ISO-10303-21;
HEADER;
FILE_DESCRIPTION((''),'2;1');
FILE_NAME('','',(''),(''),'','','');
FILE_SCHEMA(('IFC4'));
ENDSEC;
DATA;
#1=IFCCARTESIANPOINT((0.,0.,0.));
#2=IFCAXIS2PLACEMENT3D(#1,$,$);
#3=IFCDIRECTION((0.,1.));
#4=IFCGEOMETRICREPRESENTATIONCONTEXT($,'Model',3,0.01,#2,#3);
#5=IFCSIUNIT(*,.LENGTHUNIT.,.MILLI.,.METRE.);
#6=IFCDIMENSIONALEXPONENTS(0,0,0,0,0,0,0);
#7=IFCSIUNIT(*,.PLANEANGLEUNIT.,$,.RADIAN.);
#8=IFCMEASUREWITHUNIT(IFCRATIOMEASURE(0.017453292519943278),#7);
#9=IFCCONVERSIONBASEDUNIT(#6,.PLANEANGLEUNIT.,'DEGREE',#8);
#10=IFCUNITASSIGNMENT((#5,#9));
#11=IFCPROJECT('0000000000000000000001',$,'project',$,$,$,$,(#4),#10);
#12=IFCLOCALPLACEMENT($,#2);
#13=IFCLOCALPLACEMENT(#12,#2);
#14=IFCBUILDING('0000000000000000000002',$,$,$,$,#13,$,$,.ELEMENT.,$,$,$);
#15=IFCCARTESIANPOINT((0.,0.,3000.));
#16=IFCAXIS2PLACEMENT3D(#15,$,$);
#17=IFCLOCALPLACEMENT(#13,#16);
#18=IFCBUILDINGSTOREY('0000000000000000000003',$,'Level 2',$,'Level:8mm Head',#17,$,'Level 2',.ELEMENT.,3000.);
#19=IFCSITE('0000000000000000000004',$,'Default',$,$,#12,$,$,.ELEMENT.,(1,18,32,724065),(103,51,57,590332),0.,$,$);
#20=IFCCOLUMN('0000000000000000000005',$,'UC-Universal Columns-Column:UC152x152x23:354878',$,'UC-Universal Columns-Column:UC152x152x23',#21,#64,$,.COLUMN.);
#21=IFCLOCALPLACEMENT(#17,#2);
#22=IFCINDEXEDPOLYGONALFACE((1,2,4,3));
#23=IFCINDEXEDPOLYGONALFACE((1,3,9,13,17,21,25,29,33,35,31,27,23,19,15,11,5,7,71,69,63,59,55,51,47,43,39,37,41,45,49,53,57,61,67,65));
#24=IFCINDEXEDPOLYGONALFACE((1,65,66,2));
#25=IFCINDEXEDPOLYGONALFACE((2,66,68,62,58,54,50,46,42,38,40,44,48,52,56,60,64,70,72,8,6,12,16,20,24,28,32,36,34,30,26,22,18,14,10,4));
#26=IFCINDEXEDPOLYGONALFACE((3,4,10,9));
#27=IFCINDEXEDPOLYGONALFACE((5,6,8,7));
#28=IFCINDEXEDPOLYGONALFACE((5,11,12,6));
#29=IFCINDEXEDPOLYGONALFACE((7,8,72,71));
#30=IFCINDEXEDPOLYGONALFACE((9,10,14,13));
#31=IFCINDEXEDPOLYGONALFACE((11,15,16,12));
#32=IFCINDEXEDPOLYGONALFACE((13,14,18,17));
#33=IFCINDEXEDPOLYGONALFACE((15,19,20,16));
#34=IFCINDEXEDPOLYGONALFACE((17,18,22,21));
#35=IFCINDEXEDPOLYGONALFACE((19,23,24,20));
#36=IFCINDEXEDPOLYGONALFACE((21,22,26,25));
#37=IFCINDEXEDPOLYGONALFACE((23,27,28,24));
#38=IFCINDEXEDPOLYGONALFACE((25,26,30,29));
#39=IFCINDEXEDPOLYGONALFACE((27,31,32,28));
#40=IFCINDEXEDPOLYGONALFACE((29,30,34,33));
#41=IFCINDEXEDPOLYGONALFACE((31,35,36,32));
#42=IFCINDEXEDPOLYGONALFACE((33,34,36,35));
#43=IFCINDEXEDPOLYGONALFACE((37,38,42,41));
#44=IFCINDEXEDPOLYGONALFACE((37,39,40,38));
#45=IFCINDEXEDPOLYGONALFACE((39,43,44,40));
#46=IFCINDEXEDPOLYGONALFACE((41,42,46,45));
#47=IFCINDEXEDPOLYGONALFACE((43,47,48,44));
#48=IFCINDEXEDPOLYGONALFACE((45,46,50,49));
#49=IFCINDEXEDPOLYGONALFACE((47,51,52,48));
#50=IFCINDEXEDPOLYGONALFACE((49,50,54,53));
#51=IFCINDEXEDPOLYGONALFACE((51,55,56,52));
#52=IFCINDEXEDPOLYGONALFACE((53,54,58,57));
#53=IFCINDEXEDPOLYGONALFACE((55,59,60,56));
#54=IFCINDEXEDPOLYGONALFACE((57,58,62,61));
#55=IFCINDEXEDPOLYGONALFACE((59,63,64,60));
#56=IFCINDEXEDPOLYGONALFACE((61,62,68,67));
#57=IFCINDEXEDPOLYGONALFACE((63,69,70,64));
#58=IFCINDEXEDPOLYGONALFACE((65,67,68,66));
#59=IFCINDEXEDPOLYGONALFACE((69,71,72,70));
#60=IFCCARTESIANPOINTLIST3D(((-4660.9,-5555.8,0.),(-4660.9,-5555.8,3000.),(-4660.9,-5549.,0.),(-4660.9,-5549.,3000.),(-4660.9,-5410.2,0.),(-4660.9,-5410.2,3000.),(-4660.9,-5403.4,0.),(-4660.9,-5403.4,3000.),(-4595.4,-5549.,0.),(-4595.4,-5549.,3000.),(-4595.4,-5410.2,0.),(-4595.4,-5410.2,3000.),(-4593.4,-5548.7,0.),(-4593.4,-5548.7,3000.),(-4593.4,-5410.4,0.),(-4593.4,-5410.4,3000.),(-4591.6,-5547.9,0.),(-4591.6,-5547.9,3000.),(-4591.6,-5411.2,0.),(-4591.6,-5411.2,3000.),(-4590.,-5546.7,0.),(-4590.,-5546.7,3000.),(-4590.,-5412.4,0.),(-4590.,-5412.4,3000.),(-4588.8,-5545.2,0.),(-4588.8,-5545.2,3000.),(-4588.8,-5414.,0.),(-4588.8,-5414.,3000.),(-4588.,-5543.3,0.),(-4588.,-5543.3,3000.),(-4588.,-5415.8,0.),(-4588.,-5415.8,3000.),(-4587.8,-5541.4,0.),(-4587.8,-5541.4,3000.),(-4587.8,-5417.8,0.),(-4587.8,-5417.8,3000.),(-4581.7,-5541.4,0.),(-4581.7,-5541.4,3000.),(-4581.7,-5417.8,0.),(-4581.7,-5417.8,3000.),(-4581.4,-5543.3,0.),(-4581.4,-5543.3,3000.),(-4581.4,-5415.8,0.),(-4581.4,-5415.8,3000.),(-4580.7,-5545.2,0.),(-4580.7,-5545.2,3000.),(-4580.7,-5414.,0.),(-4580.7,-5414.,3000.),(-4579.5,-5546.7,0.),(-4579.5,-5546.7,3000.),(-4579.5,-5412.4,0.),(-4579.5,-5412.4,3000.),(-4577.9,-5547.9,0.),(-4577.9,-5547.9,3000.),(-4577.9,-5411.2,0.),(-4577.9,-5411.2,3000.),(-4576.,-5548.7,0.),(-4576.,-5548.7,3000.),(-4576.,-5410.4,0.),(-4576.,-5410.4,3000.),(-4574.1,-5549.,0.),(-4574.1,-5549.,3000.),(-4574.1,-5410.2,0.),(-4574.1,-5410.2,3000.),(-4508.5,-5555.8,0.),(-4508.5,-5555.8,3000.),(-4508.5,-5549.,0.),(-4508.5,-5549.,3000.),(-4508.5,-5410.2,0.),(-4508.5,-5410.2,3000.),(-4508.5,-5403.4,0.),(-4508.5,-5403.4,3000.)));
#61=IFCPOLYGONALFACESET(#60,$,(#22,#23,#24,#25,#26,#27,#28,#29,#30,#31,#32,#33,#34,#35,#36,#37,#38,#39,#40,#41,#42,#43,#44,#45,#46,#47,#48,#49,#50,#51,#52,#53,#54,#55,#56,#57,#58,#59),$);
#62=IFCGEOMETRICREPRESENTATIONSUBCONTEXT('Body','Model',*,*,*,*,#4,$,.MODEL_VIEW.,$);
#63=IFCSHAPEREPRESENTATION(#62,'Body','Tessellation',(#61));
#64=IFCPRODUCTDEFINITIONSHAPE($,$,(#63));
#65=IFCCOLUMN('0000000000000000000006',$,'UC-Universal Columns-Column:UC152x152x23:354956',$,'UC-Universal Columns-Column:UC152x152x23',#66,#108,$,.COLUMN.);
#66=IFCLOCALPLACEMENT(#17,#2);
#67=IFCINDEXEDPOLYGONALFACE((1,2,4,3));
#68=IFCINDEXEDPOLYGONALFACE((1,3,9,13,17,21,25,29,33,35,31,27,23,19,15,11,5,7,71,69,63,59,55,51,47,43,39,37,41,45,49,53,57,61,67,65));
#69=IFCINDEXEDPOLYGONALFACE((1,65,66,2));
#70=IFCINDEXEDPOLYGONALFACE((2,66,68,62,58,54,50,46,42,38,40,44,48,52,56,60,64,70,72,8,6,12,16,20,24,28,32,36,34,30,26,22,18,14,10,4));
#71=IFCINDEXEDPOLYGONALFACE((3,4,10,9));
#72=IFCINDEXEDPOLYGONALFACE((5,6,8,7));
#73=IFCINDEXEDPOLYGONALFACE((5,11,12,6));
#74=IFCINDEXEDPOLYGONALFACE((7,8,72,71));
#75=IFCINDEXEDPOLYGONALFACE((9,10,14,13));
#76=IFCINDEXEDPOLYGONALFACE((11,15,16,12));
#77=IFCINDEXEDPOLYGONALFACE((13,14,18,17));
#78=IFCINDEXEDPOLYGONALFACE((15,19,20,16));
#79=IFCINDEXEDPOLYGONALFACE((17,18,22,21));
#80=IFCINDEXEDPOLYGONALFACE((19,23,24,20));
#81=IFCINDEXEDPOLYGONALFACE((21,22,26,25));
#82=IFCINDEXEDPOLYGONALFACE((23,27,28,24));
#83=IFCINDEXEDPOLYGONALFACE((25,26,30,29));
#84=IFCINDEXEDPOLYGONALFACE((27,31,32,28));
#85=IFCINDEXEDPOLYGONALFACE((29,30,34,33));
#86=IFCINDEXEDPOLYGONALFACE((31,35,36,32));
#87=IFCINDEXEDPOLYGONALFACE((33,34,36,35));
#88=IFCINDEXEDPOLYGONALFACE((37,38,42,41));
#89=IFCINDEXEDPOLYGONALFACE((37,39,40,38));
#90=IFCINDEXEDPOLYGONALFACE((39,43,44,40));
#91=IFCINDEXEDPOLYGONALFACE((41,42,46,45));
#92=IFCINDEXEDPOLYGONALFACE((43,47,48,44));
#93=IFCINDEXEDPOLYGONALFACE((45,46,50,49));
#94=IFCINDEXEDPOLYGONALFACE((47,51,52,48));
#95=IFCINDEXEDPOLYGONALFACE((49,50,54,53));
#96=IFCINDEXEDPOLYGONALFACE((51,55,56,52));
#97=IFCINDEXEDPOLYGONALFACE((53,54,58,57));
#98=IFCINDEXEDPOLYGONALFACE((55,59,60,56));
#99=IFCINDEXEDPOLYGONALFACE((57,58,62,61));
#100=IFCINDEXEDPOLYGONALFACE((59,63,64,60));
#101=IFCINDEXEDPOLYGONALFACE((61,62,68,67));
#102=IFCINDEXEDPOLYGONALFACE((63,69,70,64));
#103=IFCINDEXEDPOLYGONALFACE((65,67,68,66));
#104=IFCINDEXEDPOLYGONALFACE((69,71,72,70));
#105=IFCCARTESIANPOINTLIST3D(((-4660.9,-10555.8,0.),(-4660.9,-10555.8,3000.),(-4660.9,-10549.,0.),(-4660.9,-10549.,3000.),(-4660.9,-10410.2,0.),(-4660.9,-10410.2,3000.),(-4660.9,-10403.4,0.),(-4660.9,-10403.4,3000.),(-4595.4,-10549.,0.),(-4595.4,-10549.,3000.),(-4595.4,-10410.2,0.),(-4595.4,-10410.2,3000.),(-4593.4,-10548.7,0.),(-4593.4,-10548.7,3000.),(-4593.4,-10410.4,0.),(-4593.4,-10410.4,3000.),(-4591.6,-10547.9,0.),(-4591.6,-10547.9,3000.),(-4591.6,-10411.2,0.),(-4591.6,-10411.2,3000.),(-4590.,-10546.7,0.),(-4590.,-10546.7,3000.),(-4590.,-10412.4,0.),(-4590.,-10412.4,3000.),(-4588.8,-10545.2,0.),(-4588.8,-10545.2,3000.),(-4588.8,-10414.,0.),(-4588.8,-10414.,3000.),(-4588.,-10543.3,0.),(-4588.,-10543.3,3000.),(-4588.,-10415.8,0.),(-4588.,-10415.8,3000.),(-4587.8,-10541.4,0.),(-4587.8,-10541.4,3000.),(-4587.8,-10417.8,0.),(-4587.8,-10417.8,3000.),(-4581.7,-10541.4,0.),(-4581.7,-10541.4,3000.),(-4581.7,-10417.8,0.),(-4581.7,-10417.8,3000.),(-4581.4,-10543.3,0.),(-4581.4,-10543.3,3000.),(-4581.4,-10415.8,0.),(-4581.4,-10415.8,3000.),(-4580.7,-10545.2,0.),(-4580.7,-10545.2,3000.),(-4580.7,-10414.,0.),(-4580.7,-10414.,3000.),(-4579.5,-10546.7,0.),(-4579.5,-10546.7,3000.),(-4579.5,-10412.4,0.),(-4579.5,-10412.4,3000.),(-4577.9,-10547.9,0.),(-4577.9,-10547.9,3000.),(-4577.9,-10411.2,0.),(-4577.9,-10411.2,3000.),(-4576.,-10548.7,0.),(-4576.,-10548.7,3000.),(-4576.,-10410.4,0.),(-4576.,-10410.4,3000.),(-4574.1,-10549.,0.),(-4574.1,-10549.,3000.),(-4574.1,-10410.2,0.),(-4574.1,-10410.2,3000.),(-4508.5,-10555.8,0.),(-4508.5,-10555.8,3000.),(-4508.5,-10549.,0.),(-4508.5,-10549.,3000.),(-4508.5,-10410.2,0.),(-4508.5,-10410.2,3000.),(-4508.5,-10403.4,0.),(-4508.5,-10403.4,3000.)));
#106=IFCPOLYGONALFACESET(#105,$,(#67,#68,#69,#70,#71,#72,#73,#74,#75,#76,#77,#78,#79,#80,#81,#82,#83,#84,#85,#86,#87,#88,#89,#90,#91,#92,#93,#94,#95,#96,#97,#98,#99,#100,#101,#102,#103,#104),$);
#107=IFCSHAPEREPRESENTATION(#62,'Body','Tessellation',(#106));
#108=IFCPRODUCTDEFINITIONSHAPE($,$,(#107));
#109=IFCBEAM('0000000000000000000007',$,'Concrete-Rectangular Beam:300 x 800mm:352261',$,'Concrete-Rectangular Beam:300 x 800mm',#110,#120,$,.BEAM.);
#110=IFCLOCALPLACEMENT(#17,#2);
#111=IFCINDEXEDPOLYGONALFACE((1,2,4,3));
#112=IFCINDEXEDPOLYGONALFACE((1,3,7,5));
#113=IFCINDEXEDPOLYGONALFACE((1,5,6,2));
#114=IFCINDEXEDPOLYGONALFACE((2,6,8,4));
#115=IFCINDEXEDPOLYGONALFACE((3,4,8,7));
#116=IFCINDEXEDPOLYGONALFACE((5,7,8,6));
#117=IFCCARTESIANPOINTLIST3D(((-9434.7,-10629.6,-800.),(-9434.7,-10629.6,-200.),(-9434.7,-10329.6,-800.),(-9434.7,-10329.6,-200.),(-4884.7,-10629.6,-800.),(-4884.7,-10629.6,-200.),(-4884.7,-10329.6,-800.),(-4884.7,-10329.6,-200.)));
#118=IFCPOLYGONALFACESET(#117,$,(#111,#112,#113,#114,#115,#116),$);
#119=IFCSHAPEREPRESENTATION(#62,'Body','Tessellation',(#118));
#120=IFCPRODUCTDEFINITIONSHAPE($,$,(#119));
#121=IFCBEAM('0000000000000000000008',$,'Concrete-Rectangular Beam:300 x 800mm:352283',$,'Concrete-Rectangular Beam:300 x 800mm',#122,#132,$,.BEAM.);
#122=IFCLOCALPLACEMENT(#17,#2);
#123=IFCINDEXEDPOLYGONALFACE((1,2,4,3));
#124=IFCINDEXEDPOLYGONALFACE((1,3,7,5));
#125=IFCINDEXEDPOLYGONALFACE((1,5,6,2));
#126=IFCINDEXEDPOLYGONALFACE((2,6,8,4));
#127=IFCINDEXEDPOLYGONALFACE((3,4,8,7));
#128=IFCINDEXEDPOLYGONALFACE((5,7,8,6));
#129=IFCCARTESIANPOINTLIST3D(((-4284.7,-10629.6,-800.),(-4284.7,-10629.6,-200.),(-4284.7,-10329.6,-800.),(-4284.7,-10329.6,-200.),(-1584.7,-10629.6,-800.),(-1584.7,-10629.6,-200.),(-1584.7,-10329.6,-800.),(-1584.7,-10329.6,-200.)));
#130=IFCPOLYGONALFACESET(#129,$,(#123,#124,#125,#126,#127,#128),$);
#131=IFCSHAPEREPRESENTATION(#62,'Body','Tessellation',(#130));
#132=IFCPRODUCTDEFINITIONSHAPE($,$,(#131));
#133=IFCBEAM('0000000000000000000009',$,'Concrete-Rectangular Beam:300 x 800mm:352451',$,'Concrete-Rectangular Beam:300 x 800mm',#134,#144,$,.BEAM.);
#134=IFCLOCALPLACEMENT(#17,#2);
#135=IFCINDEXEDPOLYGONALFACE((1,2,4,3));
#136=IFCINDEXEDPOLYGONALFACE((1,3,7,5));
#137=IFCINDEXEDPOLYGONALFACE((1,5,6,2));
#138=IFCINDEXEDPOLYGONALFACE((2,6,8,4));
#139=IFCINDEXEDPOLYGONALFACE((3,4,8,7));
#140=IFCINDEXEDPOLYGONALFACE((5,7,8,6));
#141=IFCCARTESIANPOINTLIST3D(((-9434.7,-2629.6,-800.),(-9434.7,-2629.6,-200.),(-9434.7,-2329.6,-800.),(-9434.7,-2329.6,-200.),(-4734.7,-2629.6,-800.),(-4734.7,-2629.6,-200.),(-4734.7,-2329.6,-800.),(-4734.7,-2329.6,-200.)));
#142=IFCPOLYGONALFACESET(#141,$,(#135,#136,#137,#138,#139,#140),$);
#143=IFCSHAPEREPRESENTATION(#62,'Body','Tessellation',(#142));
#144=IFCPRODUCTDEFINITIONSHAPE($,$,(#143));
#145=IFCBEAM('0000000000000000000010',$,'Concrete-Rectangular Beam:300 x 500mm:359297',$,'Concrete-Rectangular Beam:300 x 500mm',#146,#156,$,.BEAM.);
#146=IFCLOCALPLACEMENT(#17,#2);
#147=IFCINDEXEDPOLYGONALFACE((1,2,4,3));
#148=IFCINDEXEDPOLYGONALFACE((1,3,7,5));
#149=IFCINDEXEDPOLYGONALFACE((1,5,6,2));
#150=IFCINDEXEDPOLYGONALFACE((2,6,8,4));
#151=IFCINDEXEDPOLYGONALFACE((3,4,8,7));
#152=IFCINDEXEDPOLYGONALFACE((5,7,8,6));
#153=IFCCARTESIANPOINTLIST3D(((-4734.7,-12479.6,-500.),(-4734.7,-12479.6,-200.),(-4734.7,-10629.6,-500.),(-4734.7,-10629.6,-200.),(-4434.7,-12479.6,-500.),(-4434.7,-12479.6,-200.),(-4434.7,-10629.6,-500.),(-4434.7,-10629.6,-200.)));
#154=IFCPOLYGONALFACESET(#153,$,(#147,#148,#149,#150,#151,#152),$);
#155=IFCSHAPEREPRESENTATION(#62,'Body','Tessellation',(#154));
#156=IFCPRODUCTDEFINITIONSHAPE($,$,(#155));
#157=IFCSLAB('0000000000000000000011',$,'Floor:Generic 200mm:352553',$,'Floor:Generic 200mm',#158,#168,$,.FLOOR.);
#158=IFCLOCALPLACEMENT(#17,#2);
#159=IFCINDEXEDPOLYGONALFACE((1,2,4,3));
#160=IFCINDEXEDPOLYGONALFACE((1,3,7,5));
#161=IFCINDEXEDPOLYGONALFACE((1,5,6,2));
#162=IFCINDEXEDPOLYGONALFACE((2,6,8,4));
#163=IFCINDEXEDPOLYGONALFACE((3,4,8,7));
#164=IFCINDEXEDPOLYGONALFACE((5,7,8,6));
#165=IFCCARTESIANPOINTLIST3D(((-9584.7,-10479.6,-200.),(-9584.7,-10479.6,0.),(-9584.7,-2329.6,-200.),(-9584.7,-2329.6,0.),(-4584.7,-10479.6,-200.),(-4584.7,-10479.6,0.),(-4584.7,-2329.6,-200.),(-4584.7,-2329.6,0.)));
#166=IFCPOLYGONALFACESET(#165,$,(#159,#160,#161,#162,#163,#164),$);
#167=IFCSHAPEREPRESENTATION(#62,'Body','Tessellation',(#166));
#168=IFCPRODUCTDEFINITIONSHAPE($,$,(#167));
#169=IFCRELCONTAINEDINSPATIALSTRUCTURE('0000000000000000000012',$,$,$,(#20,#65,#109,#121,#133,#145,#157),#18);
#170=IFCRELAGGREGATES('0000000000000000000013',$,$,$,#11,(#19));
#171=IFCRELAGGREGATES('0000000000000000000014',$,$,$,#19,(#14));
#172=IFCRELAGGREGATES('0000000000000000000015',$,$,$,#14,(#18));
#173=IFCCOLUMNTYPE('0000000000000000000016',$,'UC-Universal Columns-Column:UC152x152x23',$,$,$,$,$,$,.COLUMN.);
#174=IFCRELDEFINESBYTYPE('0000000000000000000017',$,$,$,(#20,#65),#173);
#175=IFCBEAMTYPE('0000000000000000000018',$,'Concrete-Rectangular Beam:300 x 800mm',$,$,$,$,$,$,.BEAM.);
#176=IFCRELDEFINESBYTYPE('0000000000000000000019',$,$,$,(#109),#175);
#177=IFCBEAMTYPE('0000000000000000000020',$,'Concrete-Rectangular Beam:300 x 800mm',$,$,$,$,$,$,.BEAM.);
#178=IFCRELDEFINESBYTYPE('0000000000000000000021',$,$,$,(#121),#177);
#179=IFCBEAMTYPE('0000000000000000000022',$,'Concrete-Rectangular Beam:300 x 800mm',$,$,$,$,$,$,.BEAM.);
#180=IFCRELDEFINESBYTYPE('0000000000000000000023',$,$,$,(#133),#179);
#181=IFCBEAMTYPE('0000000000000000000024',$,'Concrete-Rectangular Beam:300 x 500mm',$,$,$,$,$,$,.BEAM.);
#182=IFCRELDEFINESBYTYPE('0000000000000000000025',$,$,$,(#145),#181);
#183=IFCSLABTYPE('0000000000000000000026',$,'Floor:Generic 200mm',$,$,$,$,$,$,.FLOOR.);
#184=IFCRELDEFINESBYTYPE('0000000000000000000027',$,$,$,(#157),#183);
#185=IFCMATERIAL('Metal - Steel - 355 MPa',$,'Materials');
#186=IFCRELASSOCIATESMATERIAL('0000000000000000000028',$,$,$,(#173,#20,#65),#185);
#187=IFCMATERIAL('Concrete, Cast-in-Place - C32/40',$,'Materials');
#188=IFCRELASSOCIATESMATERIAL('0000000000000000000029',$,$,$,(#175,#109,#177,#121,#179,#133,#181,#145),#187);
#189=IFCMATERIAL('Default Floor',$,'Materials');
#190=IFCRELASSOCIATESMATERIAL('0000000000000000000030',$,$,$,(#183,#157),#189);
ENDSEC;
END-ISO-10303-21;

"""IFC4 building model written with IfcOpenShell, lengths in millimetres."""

from ifc_helpers import new_model, entity, si_unit, converted_unit, direction, frame, origin, place, context, subcontext, project, spatial, line, arc, indexed_curve, outline, extrude, source, transform, mapped, material, type_object, type_shapes, element, save


model = new_model("IFC4")

# Units and contexts
model_context = context("Model", 3, precision=0.01, world=origin(), true_north=direction((0.0, 1.0)))
body_context = subcontext(model_context, "Body", "Model", "MODEL_VIEW")
ifc_project = project(units=[si_unit("LENGTHUNIT", "METRE", prefix="MILLI"), converted_unit("PLANEANGLEUNIT", "DEGREE", entity("IfcRatioMeasure", 0.017453292519943278), si_unit("PLANEANGLEUNIT", "RADIAN"), dimensions=[0, 0, 0, 0, 0, 0, 0])], contexts=[model_context])

# Site, building, storey
site_placement = place(None, origin())
site = spatial("IfcSite", under=ifc_project, at=site_placement, Name="Default", CompositionType="ELEMENT", RefLatitude=(1, 18, 32, 724065), RefLongitude=(103, 51, 57, 590332), RefElevation=0.0)
building_placement = place(site_placement, origin())
building = spatial("IfcBuilding", under=site, at=building_placement, CompositionType="ELEMENT")
storey_placement = place(building_placement, frame((0.0, 0.0, 3000.0)))
storey = spatial("IfcBuildingStorey", under=building, at=storey_placement, Name="Level 2", ObjectType="Level:8mm Head", LongName="Level 2", CompositionType="ELEMENT", Elevation=3000.0)

# Columns
ifc_material_1 = material(Name="Metal - Steel - 355 MPa", Category="Materials")
column_type = type_object("IfcColumnType", Name="UC-Universal Columns-Column:UC152x152x23", PredefinedType="COLUMN", material=ifc_material_1)
shared_shape_1 = source(origin(), body_context, "Body", "SweptSolid", [
    extrude(outline(indexed_curve([(69.4, -76.2), (76.2, -76.2), (76.2, 76.2), (69.4, 76.2), (69.4, 10.7), (67.2, 5.3), (61.8, 3.1), (-61.8, 3.1), (-67.2, 5.3), (-69.4, 10.7), (-69.4, 76.2), (-76.2, 76.2), (-76.2, -76.2), (-69.4, -76.2), (-69.4, -10.7), (-67.2, -5.3), (-61.8, -3.0), (61.8, -3.1), (67.2, -5.3), (69.4, -10.6)], segments=[line(1, 2, 3, 4, 5), arc(5, 6, 7), line(7, 8), arc(8, 9, 10), line(10, 11, 12, 13, 14, 15), arc(15, 16, 17), line(17, 18), arc(18, 19, 20), line(20, 1)], self_intersect=False)), frame((0.0, 0.0, 3000.0), z_axis=(0.0, 0.0, 1.0), x_axis=(0.0, -1.0, 0.0)), (0.0, 0.0, 1.0), 3000.0),
])
type_shapes(column_type, [shared_shape_1])
for number, where, name in (
    (1, (-4584.7, -5479.6, -3000.0), "UC-Universal Columns-Column:UC152x152x23:354878"),
    (2, (-4584.7, -10479.6, -3000.0), "UC-Universal Columns-Column:UC152x152x23:354956"),
):
    element("IfcColumn", number, at=place(storey_placement, frame(where)), inside=storey, type_object=column_type, material=ifc_material_1, Name=name, ObjectType="UC-Universal Columns-Column:UC152x152x23", PredefinedType="COLUMN", context=body_context, shape_type="MappedRepresentation", body=[
        mapped(shared_shape_1, transform((0.0, 0.0, 0.0), scale=1.0)),
    ])

# Beams
ifc_material_2 = material(Name="Concrete, Cast-in-Place - C32/40", Category="Materials")
beam_type_1 = type_object("IfcBeamType", Name="Concrete-Rectangular Beam:300 x 800mm", PredefinedType="BEAM", material=ifc_material_2)
shared_shape_2 = source(origin(), body_context, "Body", "SweptSolid", [
    extrude(outline(indexed_curve([(-300.0, -150.0), (300.0, -150.0), (300.0, 150.0), (-300.0, 150.0), (-300.0, -150.0)], self_intersect=False)), frame((-9434.7, -10479.6, 2500.0), z_axis=(1.0, 0.0, 0.0), x_axis=(0.0, 0.0, -1.0)), (0.0, 0.0, 1.0), 4550.0),
])
type_shapes(beam_type_1, [shared_shape_2])
beam_1_placement = place(storey_placement, frame((0.0, 0.0, -3000.0)))
element("IfcBeam", 3, at=beam_1_placement, inside=storey, type_object=beam_type_1, material=ifc_material_2, Name="Concrete-Rectangular Beam:300 x 800mm:352261", ObjectType="Concrete-Rectangular Beam:300 x 800mm", PredefinedType="BEAM", context=body_context, shape_type="MappedRepresentation", body=[
    mapped(shared_shape_2, transform((0.0, 0.0, 0.0), scale=1.0)),
])
beam_type_2 = type_object("IfcBeamType", Name="Concrete-Rectangular Beam:300 x 800mm", PredefinedType="BEAM", material=ifc_material_2)
shared_shape_3 = source(origin(), body_context, "Body", "SweptSolid", [
    extrude(outline(indexed_curve([(-300.0, -150.0), (300.0, -150.0), (300.0, 150.0), (-300.0, 150.0), (-300.0, -150.0)], self_intersect=False)), frame((-4284.7, -10479.6, 2500.0), z_axis=(1.0, 0.0, 0.0), x_axis=(0.0, 0.0, -1.0)), (0.0, 0.0, 1.0), 2700.0),
])
type_shapes(beam_type_2, [shared_shape_3])
beam_2_placement = place(storey_placement, frame((0.0, 0.0, -3000.0)))
element("IfcBeam", 4, at=beam_2_placement, inside=storey, type_object=beam_type_2, material=ifc_material_2, Name="Concrete-Rectangular Beam:300 x 800mm:352283", ObjectType="Concrete-Rectangular Beam:300 x 800mm", PredefinedType="BEAM", context=body_context, shape_type="MappedRepresentation", body=[
    mapped(shared_shape_3, transform((0.0, 0.0, 0.0), scale=1.0)),
])
beam_type_3 = type_object("IfcBeamType", Name="Concrete-Rectangular Beam:300 x 800mm", PredefinedType="BEAM", material=ifc_material_2)
shared_shape_4 = source(origin(), body_context, "Body", "SweptSolid", [
    extrude(outline(indexed_curve([(-300.0, -150.0), (300.0, -150.0), (300.0, 150.0), (-300.0, 150.0), (-300.0, -150.0)], self_intersect=False)), frame((-9434.7, -2479.6, 2500.0), z_axis=(1.0, 0.0, 0.0), x_axis=(0.0, 0.0, -1.0)), (0.0, 0.0, 1.0), 4700.0),
])
type_shapes(beam_type_3, [shared_shape_4])
beam_3_placement = place(storey_placement, frame((0.0, 0.0, -3000.0)))
element("IfcBeam", 5, at=beam_3_placement, inside=storey, type_object=beam_type_3, material=ifc_material_2, Name="Concrete-Rectangular Beam:300 x 800mm:352451", ObjectType="Concrete-Rectangular Beam:300 x 800mm", PredefinedType="BEAM", context=body_context, shape_type="MappedRepresentation", body=[
    mapped(shared_shape_4, transform((0.0, 0.0, 0.0), scale=1.0)),
])
beam_type_4 = type_object("IfcBeamType", Name="Concrete-Rectangular Beam:300 x 500mm", PredefinedType="BEAM", material=ifc_material_2)
shared_shape_5 = source(origin(), body_context, "Body", "SweptSolid", [
    extrude(outline(indexed_curve([(-150.0, -150.0), (150.0, -150.0), (150.0, 150.0), (-150.0, 150.0), (-150.0, -150.0)], self_intersect=False)), frame((-4584.7, -10629.6, 2650.0), z_axis=(0.0, -1.0, 0.0), x_axis=(-1.0, 0.0, 0.0)), (0.0, 0.0, 1.0), 1850.0),
])
type_shapes(beam_type_4, [shared_shape_5])
beam_4_placement = place(storey_placement, frame((0.0, 0.0, -3000.0)))
element("IfcBeam", 6, at=beam_4_placement, inside=storey, type_object=beam_type_4, material=ifc_material_2, Name="Concrete-Rectangular Beam:300 x 500mm:359297", ObjectType="Concrete-Rectangular Beam:300 x 500mm", PredefinedType="BEAM", context=body_context, shape_type="MappedRepresentation", body=[
    mapped(shared_shape_5, transform((0.0, 0.0, 0.0), scale=1.0)),
])

# Slab
ifc_material_3 = material(Name="Default Floor", Category="Materials")
slab_type_1 = type_object("IfcSlabType", Name="Floor:Generic 200mm", PredefinedType="FLOOR", material=ifc_material_3)
slab_1_placement = place(storey_placement, origin())
element("IfcSlab", 7, at=slab_1_placement, inside=storey, type_object=slab_type_1, material=ifc_material_3, Name="Floor:Generic 200mm:352553", ObjectType="Floor:Generic 200mm", PredefinedType="FLOOR", context=body_context, shape_type="SweptSolid", body=[
    extrude(outline(indexed_curve([(-4075.0, -2500.0), (4075.0, -2500.0), (4075.0, 2500.0), (-4075.0, 2500.0), (-4075.0, -2500.0)], self_intersect=False)), frame((-7084.7, -6404.6, 0.0), z_axis=(0.0, 0.0, -1.0), x_axis=(0.0, 1.0, 0.0)), (0.0, 0.0, 1.0), 200.0),
])

save(model, "model.ifc")
